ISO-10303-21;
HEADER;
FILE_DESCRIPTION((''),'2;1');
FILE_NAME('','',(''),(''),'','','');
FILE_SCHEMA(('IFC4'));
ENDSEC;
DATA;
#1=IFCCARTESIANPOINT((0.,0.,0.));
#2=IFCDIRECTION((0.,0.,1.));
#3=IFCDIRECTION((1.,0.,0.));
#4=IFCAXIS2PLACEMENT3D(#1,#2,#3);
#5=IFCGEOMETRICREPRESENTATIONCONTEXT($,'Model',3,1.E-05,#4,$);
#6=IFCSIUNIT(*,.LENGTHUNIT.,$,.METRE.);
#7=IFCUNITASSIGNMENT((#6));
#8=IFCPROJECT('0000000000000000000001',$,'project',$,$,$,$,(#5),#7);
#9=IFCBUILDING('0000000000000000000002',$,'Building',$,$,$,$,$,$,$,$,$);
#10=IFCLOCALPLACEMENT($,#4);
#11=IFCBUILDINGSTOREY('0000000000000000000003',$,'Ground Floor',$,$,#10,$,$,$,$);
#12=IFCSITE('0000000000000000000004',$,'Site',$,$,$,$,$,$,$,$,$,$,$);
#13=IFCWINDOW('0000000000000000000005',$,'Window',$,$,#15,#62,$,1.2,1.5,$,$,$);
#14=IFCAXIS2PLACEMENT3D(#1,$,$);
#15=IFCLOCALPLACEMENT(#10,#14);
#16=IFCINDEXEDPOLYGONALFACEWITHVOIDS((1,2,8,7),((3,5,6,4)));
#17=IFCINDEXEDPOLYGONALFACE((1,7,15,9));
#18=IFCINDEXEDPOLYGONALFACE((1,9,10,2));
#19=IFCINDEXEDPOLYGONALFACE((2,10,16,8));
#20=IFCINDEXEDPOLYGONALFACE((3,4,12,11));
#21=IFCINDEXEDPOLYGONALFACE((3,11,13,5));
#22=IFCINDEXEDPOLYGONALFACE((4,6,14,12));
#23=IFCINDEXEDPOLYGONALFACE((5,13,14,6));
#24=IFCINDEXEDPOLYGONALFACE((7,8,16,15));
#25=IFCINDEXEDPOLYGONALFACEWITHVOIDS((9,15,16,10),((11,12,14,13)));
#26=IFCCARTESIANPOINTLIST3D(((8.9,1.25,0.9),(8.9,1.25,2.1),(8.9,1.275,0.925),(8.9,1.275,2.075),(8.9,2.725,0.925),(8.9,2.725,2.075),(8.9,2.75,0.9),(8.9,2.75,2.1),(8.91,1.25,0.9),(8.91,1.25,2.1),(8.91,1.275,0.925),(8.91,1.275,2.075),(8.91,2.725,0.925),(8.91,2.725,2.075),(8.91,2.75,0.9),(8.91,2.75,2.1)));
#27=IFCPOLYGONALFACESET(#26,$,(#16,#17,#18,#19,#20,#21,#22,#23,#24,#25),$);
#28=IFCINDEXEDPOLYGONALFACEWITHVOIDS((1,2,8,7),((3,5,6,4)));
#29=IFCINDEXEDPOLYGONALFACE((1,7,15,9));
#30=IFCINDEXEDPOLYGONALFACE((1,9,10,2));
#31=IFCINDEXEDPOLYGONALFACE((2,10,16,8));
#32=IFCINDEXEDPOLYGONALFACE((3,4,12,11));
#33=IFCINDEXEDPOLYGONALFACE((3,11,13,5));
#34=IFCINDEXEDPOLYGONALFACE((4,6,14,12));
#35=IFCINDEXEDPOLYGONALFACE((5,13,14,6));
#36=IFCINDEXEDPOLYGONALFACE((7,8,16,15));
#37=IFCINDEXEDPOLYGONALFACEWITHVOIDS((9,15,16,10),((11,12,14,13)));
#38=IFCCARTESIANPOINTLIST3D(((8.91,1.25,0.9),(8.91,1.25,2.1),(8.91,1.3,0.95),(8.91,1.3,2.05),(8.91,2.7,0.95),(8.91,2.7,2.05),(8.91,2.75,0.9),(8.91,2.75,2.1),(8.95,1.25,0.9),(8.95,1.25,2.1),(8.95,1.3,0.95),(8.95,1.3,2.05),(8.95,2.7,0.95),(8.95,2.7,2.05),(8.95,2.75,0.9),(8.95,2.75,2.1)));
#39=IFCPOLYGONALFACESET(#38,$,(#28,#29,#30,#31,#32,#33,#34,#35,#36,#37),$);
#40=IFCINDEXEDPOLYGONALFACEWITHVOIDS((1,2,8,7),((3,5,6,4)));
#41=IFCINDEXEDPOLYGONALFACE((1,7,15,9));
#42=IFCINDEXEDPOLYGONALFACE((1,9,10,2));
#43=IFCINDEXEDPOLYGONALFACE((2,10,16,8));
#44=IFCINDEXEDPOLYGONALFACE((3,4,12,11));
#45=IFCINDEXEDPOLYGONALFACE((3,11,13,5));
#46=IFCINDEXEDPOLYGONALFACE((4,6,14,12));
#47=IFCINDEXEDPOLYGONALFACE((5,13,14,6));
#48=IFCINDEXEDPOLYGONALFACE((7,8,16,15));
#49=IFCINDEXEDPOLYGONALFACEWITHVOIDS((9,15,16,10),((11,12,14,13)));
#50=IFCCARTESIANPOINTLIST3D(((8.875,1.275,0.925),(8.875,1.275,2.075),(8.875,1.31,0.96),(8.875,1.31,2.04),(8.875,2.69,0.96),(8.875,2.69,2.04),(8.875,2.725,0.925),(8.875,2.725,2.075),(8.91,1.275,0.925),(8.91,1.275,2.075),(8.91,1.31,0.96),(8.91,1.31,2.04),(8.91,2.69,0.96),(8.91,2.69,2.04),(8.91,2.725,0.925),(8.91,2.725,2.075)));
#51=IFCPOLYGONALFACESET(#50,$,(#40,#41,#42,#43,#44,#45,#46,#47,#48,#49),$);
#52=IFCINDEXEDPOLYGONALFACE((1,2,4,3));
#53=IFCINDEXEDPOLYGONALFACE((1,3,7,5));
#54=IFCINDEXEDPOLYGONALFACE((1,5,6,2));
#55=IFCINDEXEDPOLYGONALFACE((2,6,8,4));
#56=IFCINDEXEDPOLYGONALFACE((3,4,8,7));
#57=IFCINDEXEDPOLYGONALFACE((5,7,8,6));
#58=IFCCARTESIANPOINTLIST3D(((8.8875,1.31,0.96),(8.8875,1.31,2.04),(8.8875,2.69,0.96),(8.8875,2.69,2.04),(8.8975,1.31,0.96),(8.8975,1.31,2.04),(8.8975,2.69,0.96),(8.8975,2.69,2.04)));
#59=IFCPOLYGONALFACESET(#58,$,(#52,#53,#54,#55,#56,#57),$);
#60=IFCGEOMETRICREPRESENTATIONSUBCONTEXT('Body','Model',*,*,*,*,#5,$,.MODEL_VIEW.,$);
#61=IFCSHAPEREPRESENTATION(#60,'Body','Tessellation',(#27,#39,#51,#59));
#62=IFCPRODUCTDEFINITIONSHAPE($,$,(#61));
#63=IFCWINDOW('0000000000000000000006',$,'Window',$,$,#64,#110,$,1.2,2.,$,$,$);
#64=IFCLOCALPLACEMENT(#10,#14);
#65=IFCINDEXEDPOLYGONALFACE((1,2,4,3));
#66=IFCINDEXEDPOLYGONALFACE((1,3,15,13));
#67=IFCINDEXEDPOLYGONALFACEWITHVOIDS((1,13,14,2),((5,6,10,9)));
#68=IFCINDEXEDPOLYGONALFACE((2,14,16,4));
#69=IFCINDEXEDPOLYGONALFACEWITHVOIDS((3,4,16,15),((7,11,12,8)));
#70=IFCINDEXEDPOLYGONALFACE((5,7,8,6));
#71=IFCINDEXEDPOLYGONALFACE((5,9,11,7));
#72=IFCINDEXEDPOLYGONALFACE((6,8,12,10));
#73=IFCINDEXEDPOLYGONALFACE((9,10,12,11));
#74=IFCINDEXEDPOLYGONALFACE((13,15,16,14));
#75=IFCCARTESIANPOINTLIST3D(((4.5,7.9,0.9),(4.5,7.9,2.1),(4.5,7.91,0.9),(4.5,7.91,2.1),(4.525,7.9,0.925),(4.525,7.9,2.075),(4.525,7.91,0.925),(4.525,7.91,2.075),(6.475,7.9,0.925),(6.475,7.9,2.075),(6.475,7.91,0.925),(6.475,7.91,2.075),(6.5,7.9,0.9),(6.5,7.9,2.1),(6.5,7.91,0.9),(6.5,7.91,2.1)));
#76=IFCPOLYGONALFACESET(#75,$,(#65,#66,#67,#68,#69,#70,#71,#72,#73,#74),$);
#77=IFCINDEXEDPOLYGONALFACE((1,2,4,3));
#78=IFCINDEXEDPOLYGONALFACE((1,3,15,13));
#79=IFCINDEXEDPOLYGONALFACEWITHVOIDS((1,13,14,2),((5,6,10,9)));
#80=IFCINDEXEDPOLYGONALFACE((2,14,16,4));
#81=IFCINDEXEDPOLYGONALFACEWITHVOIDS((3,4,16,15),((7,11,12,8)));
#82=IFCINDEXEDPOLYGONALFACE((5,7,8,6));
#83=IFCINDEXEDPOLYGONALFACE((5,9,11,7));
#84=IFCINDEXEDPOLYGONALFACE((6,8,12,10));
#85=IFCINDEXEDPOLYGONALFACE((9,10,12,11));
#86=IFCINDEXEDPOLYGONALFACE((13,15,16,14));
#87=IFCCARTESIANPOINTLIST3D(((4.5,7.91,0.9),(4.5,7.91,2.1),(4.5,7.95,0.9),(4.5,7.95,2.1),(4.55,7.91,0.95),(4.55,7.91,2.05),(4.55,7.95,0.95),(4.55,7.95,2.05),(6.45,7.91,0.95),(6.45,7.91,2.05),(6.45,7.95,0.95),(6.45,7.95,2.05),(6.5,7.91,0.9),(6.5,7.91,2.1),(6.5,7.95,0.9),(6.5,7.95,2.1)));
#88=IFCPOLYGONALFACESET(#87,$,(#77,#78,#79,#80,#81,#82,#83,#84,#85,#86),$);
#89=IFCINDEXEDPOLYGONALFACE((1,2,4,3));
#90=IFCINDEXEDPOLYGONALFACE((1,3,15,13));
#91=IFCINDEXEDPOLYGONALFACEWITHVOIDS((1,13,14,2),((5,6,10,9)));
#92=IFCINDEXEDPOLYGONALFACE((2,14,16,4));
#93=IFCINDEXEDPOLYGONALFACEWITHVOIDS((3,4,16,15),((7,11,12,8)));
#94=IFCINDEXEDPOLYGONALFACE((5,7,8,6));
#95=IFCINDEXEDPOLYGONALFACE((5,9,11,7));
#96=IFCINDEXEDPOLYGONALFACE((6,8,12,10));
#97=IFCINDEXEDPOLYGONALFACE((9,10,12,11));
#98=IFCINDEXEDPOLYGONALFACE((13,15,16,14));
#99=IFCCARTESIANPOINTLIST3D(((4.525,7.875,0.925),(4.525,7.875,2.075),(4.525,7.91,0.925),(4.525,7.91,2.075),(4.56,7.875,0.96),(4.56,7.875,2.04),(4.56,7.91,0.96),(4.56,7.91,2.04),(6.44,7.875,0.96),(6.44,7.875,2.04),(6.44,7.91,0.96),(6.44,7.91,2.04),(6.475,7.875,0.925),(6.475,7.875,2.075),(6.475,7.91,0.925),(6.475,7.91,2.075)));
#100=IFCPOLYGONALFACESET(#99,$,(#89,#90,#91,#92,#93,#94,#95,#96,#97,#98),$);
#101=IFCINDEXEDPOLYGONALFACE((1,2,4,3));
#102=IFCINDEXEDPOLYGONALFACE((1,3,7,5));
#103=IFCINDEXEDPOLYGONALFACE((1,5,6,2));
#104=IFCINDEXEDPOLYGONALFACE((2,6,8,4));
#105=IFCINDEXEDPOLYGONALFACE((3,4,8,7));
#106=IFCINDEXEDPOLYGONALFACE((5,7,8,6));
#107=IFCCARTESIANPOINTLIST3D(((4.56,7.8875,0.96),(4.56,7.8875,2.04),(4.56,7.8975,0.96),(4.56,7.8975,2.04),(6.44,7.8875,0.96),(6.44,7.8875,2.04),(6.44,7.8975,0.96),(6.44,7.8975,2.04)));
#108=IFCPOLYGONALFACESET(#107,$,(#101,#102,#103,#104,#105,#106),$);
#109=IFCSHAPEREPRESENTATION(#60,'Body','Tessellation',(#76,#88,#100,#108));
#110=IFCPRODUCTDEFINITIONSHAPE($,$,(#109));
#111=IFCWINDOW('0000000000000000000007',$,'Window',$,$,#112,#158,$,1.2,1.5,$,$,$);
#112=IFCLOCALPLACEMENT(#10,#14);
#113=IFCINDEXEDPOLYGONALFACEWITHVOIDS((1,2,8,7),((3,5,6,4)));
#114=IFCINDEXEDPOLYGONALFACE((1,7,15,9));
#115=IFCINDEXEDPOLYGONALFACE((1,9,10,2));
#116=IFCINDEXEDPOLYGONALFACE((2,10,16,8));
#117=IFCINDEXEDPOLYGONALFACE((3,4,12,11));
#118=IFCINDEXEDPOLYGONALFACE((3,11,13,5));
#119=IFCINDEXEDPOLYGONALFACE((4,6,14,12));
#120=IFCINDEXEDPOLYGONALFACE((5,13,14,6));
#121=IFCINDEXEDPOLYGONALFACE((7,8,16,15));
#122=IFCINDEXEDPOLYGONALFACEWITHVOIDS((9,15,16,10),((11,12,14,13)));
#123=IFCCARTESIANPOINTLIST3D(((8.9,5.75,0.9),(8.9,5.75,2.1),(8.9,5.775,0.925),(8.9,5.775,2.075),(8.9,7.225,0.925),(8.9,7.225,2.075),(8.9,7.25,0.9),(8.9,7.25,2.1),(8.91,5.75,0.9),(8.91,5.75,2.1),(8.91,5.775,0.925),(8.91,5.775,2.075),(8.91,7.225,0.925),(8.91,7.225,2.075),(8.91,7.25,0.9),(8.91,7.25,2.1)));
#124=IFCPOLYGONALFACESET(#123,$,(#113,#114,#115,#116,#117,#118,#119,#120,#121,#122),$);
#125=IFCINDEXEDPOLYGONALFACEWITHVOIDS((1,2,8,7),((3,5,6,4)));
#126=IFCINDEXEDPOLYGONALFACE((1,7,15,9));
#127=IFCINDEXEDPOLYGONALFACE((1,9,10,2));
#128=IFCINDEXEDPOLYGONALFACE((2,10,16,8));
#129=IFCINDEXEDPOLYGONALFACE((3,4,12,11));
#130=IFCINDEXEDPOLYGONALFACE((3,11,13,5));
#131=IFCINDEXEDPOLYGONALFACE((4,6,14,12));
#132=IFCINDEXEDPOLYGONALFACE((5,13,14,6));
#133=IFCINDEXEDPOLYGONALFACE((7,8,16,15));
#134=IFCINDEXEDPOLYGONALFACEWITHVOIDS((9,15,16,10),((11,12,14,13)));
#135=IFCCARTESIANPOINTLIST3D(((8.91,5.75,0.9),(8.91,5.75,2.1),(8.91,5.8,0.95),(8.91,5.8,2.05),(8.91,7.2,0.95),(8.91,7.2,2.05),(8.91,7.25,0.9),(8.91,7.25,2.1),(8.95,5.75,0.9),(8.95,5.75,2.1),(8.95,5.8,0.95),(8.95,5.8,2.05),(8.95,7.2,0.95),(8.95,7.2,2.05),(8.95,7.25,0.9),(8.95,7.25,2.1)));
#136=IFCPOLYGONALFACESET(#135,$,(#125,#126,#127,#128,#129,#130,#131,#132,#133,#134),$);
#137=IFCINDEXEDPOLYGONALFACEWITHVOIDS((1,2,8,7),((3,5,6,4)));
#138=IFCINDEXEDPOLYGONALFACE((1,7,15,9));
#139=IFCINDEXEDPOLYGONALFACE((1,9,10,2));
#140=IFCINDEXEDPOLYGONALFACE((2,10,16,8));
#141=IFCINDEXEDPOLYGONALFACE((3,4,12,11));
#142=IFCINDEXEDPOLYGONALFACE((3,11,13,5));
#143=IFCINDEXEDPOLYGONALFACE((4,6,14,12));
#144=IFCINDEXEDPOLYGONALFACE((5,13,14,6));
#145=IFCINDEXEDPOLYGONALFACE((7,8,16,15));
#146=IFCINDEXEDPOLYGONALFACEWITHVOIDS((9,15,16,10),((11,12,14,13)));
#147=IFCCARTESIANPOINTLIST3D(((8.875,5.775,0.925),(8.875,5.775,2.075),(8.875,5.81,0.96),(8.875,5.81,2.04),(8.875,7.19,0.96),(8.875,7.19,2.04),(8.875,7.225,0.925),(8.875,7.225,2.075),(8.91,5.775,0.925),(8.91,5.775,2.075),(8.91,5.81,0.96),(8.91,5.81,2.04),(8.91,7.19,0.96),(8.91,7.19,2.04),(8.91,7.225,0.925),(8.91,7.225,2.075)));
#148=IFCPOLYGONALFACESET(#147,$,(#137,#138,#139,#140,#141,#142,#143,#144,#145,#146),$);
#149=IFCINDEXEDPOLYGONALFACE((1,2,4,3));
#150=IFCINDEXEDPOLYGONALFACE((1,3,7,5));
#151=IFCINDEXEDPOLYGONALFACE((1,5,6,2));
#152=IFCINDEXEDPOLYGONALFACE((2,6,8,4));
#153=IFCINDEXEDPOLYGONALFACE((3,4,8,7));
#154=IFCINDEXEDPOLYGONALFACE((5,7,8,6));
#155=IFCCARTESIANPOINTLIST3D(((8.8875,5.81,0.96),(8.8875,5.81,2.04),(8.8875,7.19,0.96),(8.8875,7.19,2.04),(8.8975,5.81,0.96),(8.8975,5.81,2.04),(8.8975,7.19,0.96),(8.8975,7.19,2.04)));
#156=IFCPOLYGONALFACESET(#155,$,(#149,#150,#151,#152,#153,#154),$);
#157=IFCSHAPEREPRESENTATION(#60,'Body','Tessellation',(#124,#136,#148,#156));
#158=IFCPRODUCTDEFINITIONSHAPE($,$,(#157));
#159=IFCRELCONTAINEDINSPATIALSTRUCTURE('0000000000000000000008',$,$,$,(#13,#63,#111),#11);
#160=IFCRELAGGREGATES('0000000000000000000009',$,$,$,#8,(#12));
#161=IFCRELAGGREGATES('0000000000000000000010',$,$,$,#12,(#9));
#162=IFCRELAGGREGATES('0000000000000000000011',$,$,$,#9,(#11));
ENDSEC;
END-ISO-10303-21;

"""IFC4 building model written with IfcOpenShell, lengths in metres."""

from ifc_helpers import new_model, si_unit, frame, origin_with_axes, place, context, subcontext, project, spatial, line, indexed_curve, outline, extrude, element, save


model = new_model("IFC4")

# Units and contexts
model_context = context("Model", 3, precision=1e-05, world=origin_with_axes())
body_context = subcontext(model_context, "Body", "Model", "MODEL_VIEW")
ifc_project = project(units=[si_unit("LENGTHUNIT", "METRE")], contexts=[model_context])

# Site, building, storey
site = spatial("IfcSite", under=ifc_project, Name="Site")
building = spatial("IfcBuilding", under=site, Name="Building")
storey_placement = place(None, origin_with_axes())
storey = spatial("IfcBuildingStorey", under=building, at=storey_placement, Name="Ground Floor")

# Windows
for number, where, z_axis, x_axis, name in (
    (1, (9.0, 1.25, 0.9), (0.0, 0.0, 1.0), (0.0, 1.0, 0.0), "Window"),
):
    element("IfcWindow", number, at=place(storey_placement, frame(where, z_axis=z_axis, x_axis=x_axis)), inside=storey, Name=name, OverallHeight=1.2, OverallWidth=1.5, context=body_context, shape_type="SweptSolid", body=[
        extrude(outline(indexed_curve([(0.0, 0.0), (1.5, 0.0), (1.5, 1.2), (0.0, 1.2)], segments=[line(1, 2, 3, 4, 1)]), holes=[indexed_curve([(0.025, 0.025), (1.475, 0.025), (1.475, 1.175), (0.025, 1.175)], segments=[line(1, 2, 3, 4, 1)])]), frame((0.0, 0.09, 0.0), z_axis=(0.0, -1.0, 0.0), x_axis=(1.0, 0.0, 0.0)), (0.0, 0.0, -1.0), 0.01),
        extrude(outline(indexed_curve([(0.0, 0.0), (1.5, 0.0), (1.5, 1.2), (0.0, 1.2)], segments=[line(1, 2, 3, 4, 1)]), holes=[indexed_curve([(0.05, 0.05), (1.45, 0.05), (1.45, 1.15), (0.05, 1.15)], segments=[line(1, 2, 3, 4, 1)])]), frame((0.0, 0.05, 0.0), z_axis=(0.0, -1.0, 0.0), x_axis=(1.0, 0.0, 0.0)), (0.0, 0.0, -1.0), 0.04),
        extrude(outline(indexed_curve([(0.0, 0.0), (1.45, 0.0), (1.45, 1.15), (0.0, 1.15)], segments=[line(1, 2, 3, 4, 1)]), holes=[indexed_curve([(0.035, 0.035), (1.415, 0.035), (1.415, 1.115), (0.035, 1.115)], segments=[line(1, 2, 3, 4, 1)])]), frame((0.025, 0.09, 0.025), z_axis=(0.0, -1.0, 0.0), x_axis=(1.0, 0.0, 0.0)), (0.0, 0.0, -1.0), 0.035),
        extrude(outline(indexed_curve([(0.035, 0.035), (1.415, 0.035), (1.415, 1.115), (0.035, 1.115)], segments=[line(1, 2, 3, 4, 1)])), frame((0.025, 0.1025, 0.025), z_axis=(0.0, -1.0, 0.0), x_axis=(1.0, 0.0, 0.0)), (0.0, 0.0, -1.0), 0.01),
    ])
window_1_placement = place(storey_placement, frame((6.5, 8.0, 0.9), z_axis=(0.0, 0.0, 1.0), x_axis=(-1.0, 0.0, 0.0)))
element("IfcWindow", 2, at=window_1_placement, inside=storey, Name="Window", OverallHeight=1.2, OverallWidth=2.0, context=body_context, shape_type="SweptSolid", body=[
    extrude(outline(indexed_curve([(0.0, 0.0), (2.0, 0.0), (2.0, 1.2), (0.0, 1.2)], segments=[line(1, 2, 3, 4, 1)]), holes=[indexed_curve([(0.025, 0.025), (1.975, 0.025), (1.975, 1.175), (0.025, 1.175)], segments=[line(1, 2, 3, 4, 1)])]), frame((0.0, 0.09, 0.0), z_axis=(0.0, -1.0, 0.0), x_axis=(1.0, 0.0, 0.0)), (0.0, 0.0, -1.0), 0.01),
    extrude(outline(indexed_curve([(0.0, 0.0), (2.0, 0.0), (2.0, 1.2), (0.0, 1.2)], segments=[line(1, 2, 3, 4, 1)]), holes=[indexed_curve([(0.05, 0.05), (1.95, 0.05), (1.95, 1.15), (0.05, 1.15)], segments=[line(1, 2, 3, 4, 1)])]), frame((0.0, 0.05, 0.0), z_axis=(0.0, -1.0, 0.0), x_axis=(1.0, 0.0, 0.0)), (0.0, 0.0, -1.0), 0.04),
    extrude(outline(indexed_curve([(0.0, 0.0), (1.95, 0.0), (1.95, 1.15), (0.0, 1.15)], segments=[line(1, 2, 3, 4, 1)]), holes=[indexed_curve([(0.035, 0.035), (1.915, 0.035), (1.915, 1.115), (0.035, 1.115)], segments=[line(1, 2, 3, 4, 1)])]), frame((0.025, 0.09, 0.025), z_axis=(0.0, -1.0, 0.0), x_axis=(1.0, 0.0, 0.0)), (0.0, 0.0, -1.0), 0.035),
    extrude(outline(indexed_curve([(0.035, 0.035), (1.915, 0.035), (1.915, 1.115), (0.035, 1.115)], segments=[line(1, 2, 3, 4, 1)])), frame((0.025, 0.1025, 0.025), z_axis=(0.0, -1.0, 0.0), x_axis=(1.0, 0.0, 0.0)), (0.0, 0.0, -1.0), 0.01),
])
window_2_placement = place(storey_placement, frame((9.0, 5.75, 0.9), z_axis=(0.0, 0.0, 1.0), x_axis=(0.0, 1.0, 0.0)))
element("IfcWindow", 3, at=window_2_placement, inside=storey, Name="Window", OverallHeight=1.2, OverallWidth=1.5, context=body_context, shape_type="SweptSolid", body=[
    extrude(outline(indexed_curve([(0.0, 0.0), (1.5, 0.0), (1.5, 1.2), (0.0, 1.2)], segments=[line(1, 2, 3, 4, 1)]), holes=[indexed_curve([(0.025, 0.025), (1.475, 0.025), (1.475, 1.175), (0.025, 1.175)], segments=[line(1, 2, 3, 4, 1)])]), frame((0.0, 0.09, 0.0), z_axis=(0.0, -1.0, 0.0), x_axis=(1.0, 0.0, 0.0)), (0.0, 0.0, -1.0), 0.01),
    extrude(outline(indexed_curve([(0.0, 0.0), (1.5, 0.0), (1.5, 1.2), (0.0, 1.2)], segments=[line(1, 2, 3, 4, 1)]), holes=[indexed_curve([(0.05, 0.05), (1.45, 0.05), (1.45, 1.15), (0.05, 1.15)], segments=[line(1, 2, 3, 4, 1)])]), frame((0.0, 0.05, 0.0), z_axis=(0.0, -1.0, 0.0), x_axis=(1.0, 0.0, 0.0)), (0.0, 0.0, -1.0), 0.04),
    extrude(outline(indexed_curve([(0.0, 0.0), (1.45, 0.0), (1.45, 1.15), (0.0, 1.15)], segments=[line(1, 2, 3, 4, 1)]), holes=[indexed_curve([(0.035, 0.035), (1.415, 0.035), (1.415, 1.115), (0.035, 1.115)], segments=[line(1, 2, 3, 4, 1)])]), frame((0.025, 0.09, 0.025), z_axis=(0.0, -1.0, 0.0), x_axis=(1.0, 0.0, 0.0)), (0.0, 0.0, -1.0), 0.035),
    extrude(outline(indexed_curve([(0.035, 0.035), (1.415, 0.035), (1.415, 1.115), (0.035, 1.115)], segments=[line(1, 2, 3, 4, 1)])), frame((0.025, 0.1025, 0.025), z_axis=(0.0, -1.0, 0.0), x_axis=(1.0, 0.0, 0.0)), (0.0, 0.0, -1.0), 0.01),
])

save(model, "model.ifc")
